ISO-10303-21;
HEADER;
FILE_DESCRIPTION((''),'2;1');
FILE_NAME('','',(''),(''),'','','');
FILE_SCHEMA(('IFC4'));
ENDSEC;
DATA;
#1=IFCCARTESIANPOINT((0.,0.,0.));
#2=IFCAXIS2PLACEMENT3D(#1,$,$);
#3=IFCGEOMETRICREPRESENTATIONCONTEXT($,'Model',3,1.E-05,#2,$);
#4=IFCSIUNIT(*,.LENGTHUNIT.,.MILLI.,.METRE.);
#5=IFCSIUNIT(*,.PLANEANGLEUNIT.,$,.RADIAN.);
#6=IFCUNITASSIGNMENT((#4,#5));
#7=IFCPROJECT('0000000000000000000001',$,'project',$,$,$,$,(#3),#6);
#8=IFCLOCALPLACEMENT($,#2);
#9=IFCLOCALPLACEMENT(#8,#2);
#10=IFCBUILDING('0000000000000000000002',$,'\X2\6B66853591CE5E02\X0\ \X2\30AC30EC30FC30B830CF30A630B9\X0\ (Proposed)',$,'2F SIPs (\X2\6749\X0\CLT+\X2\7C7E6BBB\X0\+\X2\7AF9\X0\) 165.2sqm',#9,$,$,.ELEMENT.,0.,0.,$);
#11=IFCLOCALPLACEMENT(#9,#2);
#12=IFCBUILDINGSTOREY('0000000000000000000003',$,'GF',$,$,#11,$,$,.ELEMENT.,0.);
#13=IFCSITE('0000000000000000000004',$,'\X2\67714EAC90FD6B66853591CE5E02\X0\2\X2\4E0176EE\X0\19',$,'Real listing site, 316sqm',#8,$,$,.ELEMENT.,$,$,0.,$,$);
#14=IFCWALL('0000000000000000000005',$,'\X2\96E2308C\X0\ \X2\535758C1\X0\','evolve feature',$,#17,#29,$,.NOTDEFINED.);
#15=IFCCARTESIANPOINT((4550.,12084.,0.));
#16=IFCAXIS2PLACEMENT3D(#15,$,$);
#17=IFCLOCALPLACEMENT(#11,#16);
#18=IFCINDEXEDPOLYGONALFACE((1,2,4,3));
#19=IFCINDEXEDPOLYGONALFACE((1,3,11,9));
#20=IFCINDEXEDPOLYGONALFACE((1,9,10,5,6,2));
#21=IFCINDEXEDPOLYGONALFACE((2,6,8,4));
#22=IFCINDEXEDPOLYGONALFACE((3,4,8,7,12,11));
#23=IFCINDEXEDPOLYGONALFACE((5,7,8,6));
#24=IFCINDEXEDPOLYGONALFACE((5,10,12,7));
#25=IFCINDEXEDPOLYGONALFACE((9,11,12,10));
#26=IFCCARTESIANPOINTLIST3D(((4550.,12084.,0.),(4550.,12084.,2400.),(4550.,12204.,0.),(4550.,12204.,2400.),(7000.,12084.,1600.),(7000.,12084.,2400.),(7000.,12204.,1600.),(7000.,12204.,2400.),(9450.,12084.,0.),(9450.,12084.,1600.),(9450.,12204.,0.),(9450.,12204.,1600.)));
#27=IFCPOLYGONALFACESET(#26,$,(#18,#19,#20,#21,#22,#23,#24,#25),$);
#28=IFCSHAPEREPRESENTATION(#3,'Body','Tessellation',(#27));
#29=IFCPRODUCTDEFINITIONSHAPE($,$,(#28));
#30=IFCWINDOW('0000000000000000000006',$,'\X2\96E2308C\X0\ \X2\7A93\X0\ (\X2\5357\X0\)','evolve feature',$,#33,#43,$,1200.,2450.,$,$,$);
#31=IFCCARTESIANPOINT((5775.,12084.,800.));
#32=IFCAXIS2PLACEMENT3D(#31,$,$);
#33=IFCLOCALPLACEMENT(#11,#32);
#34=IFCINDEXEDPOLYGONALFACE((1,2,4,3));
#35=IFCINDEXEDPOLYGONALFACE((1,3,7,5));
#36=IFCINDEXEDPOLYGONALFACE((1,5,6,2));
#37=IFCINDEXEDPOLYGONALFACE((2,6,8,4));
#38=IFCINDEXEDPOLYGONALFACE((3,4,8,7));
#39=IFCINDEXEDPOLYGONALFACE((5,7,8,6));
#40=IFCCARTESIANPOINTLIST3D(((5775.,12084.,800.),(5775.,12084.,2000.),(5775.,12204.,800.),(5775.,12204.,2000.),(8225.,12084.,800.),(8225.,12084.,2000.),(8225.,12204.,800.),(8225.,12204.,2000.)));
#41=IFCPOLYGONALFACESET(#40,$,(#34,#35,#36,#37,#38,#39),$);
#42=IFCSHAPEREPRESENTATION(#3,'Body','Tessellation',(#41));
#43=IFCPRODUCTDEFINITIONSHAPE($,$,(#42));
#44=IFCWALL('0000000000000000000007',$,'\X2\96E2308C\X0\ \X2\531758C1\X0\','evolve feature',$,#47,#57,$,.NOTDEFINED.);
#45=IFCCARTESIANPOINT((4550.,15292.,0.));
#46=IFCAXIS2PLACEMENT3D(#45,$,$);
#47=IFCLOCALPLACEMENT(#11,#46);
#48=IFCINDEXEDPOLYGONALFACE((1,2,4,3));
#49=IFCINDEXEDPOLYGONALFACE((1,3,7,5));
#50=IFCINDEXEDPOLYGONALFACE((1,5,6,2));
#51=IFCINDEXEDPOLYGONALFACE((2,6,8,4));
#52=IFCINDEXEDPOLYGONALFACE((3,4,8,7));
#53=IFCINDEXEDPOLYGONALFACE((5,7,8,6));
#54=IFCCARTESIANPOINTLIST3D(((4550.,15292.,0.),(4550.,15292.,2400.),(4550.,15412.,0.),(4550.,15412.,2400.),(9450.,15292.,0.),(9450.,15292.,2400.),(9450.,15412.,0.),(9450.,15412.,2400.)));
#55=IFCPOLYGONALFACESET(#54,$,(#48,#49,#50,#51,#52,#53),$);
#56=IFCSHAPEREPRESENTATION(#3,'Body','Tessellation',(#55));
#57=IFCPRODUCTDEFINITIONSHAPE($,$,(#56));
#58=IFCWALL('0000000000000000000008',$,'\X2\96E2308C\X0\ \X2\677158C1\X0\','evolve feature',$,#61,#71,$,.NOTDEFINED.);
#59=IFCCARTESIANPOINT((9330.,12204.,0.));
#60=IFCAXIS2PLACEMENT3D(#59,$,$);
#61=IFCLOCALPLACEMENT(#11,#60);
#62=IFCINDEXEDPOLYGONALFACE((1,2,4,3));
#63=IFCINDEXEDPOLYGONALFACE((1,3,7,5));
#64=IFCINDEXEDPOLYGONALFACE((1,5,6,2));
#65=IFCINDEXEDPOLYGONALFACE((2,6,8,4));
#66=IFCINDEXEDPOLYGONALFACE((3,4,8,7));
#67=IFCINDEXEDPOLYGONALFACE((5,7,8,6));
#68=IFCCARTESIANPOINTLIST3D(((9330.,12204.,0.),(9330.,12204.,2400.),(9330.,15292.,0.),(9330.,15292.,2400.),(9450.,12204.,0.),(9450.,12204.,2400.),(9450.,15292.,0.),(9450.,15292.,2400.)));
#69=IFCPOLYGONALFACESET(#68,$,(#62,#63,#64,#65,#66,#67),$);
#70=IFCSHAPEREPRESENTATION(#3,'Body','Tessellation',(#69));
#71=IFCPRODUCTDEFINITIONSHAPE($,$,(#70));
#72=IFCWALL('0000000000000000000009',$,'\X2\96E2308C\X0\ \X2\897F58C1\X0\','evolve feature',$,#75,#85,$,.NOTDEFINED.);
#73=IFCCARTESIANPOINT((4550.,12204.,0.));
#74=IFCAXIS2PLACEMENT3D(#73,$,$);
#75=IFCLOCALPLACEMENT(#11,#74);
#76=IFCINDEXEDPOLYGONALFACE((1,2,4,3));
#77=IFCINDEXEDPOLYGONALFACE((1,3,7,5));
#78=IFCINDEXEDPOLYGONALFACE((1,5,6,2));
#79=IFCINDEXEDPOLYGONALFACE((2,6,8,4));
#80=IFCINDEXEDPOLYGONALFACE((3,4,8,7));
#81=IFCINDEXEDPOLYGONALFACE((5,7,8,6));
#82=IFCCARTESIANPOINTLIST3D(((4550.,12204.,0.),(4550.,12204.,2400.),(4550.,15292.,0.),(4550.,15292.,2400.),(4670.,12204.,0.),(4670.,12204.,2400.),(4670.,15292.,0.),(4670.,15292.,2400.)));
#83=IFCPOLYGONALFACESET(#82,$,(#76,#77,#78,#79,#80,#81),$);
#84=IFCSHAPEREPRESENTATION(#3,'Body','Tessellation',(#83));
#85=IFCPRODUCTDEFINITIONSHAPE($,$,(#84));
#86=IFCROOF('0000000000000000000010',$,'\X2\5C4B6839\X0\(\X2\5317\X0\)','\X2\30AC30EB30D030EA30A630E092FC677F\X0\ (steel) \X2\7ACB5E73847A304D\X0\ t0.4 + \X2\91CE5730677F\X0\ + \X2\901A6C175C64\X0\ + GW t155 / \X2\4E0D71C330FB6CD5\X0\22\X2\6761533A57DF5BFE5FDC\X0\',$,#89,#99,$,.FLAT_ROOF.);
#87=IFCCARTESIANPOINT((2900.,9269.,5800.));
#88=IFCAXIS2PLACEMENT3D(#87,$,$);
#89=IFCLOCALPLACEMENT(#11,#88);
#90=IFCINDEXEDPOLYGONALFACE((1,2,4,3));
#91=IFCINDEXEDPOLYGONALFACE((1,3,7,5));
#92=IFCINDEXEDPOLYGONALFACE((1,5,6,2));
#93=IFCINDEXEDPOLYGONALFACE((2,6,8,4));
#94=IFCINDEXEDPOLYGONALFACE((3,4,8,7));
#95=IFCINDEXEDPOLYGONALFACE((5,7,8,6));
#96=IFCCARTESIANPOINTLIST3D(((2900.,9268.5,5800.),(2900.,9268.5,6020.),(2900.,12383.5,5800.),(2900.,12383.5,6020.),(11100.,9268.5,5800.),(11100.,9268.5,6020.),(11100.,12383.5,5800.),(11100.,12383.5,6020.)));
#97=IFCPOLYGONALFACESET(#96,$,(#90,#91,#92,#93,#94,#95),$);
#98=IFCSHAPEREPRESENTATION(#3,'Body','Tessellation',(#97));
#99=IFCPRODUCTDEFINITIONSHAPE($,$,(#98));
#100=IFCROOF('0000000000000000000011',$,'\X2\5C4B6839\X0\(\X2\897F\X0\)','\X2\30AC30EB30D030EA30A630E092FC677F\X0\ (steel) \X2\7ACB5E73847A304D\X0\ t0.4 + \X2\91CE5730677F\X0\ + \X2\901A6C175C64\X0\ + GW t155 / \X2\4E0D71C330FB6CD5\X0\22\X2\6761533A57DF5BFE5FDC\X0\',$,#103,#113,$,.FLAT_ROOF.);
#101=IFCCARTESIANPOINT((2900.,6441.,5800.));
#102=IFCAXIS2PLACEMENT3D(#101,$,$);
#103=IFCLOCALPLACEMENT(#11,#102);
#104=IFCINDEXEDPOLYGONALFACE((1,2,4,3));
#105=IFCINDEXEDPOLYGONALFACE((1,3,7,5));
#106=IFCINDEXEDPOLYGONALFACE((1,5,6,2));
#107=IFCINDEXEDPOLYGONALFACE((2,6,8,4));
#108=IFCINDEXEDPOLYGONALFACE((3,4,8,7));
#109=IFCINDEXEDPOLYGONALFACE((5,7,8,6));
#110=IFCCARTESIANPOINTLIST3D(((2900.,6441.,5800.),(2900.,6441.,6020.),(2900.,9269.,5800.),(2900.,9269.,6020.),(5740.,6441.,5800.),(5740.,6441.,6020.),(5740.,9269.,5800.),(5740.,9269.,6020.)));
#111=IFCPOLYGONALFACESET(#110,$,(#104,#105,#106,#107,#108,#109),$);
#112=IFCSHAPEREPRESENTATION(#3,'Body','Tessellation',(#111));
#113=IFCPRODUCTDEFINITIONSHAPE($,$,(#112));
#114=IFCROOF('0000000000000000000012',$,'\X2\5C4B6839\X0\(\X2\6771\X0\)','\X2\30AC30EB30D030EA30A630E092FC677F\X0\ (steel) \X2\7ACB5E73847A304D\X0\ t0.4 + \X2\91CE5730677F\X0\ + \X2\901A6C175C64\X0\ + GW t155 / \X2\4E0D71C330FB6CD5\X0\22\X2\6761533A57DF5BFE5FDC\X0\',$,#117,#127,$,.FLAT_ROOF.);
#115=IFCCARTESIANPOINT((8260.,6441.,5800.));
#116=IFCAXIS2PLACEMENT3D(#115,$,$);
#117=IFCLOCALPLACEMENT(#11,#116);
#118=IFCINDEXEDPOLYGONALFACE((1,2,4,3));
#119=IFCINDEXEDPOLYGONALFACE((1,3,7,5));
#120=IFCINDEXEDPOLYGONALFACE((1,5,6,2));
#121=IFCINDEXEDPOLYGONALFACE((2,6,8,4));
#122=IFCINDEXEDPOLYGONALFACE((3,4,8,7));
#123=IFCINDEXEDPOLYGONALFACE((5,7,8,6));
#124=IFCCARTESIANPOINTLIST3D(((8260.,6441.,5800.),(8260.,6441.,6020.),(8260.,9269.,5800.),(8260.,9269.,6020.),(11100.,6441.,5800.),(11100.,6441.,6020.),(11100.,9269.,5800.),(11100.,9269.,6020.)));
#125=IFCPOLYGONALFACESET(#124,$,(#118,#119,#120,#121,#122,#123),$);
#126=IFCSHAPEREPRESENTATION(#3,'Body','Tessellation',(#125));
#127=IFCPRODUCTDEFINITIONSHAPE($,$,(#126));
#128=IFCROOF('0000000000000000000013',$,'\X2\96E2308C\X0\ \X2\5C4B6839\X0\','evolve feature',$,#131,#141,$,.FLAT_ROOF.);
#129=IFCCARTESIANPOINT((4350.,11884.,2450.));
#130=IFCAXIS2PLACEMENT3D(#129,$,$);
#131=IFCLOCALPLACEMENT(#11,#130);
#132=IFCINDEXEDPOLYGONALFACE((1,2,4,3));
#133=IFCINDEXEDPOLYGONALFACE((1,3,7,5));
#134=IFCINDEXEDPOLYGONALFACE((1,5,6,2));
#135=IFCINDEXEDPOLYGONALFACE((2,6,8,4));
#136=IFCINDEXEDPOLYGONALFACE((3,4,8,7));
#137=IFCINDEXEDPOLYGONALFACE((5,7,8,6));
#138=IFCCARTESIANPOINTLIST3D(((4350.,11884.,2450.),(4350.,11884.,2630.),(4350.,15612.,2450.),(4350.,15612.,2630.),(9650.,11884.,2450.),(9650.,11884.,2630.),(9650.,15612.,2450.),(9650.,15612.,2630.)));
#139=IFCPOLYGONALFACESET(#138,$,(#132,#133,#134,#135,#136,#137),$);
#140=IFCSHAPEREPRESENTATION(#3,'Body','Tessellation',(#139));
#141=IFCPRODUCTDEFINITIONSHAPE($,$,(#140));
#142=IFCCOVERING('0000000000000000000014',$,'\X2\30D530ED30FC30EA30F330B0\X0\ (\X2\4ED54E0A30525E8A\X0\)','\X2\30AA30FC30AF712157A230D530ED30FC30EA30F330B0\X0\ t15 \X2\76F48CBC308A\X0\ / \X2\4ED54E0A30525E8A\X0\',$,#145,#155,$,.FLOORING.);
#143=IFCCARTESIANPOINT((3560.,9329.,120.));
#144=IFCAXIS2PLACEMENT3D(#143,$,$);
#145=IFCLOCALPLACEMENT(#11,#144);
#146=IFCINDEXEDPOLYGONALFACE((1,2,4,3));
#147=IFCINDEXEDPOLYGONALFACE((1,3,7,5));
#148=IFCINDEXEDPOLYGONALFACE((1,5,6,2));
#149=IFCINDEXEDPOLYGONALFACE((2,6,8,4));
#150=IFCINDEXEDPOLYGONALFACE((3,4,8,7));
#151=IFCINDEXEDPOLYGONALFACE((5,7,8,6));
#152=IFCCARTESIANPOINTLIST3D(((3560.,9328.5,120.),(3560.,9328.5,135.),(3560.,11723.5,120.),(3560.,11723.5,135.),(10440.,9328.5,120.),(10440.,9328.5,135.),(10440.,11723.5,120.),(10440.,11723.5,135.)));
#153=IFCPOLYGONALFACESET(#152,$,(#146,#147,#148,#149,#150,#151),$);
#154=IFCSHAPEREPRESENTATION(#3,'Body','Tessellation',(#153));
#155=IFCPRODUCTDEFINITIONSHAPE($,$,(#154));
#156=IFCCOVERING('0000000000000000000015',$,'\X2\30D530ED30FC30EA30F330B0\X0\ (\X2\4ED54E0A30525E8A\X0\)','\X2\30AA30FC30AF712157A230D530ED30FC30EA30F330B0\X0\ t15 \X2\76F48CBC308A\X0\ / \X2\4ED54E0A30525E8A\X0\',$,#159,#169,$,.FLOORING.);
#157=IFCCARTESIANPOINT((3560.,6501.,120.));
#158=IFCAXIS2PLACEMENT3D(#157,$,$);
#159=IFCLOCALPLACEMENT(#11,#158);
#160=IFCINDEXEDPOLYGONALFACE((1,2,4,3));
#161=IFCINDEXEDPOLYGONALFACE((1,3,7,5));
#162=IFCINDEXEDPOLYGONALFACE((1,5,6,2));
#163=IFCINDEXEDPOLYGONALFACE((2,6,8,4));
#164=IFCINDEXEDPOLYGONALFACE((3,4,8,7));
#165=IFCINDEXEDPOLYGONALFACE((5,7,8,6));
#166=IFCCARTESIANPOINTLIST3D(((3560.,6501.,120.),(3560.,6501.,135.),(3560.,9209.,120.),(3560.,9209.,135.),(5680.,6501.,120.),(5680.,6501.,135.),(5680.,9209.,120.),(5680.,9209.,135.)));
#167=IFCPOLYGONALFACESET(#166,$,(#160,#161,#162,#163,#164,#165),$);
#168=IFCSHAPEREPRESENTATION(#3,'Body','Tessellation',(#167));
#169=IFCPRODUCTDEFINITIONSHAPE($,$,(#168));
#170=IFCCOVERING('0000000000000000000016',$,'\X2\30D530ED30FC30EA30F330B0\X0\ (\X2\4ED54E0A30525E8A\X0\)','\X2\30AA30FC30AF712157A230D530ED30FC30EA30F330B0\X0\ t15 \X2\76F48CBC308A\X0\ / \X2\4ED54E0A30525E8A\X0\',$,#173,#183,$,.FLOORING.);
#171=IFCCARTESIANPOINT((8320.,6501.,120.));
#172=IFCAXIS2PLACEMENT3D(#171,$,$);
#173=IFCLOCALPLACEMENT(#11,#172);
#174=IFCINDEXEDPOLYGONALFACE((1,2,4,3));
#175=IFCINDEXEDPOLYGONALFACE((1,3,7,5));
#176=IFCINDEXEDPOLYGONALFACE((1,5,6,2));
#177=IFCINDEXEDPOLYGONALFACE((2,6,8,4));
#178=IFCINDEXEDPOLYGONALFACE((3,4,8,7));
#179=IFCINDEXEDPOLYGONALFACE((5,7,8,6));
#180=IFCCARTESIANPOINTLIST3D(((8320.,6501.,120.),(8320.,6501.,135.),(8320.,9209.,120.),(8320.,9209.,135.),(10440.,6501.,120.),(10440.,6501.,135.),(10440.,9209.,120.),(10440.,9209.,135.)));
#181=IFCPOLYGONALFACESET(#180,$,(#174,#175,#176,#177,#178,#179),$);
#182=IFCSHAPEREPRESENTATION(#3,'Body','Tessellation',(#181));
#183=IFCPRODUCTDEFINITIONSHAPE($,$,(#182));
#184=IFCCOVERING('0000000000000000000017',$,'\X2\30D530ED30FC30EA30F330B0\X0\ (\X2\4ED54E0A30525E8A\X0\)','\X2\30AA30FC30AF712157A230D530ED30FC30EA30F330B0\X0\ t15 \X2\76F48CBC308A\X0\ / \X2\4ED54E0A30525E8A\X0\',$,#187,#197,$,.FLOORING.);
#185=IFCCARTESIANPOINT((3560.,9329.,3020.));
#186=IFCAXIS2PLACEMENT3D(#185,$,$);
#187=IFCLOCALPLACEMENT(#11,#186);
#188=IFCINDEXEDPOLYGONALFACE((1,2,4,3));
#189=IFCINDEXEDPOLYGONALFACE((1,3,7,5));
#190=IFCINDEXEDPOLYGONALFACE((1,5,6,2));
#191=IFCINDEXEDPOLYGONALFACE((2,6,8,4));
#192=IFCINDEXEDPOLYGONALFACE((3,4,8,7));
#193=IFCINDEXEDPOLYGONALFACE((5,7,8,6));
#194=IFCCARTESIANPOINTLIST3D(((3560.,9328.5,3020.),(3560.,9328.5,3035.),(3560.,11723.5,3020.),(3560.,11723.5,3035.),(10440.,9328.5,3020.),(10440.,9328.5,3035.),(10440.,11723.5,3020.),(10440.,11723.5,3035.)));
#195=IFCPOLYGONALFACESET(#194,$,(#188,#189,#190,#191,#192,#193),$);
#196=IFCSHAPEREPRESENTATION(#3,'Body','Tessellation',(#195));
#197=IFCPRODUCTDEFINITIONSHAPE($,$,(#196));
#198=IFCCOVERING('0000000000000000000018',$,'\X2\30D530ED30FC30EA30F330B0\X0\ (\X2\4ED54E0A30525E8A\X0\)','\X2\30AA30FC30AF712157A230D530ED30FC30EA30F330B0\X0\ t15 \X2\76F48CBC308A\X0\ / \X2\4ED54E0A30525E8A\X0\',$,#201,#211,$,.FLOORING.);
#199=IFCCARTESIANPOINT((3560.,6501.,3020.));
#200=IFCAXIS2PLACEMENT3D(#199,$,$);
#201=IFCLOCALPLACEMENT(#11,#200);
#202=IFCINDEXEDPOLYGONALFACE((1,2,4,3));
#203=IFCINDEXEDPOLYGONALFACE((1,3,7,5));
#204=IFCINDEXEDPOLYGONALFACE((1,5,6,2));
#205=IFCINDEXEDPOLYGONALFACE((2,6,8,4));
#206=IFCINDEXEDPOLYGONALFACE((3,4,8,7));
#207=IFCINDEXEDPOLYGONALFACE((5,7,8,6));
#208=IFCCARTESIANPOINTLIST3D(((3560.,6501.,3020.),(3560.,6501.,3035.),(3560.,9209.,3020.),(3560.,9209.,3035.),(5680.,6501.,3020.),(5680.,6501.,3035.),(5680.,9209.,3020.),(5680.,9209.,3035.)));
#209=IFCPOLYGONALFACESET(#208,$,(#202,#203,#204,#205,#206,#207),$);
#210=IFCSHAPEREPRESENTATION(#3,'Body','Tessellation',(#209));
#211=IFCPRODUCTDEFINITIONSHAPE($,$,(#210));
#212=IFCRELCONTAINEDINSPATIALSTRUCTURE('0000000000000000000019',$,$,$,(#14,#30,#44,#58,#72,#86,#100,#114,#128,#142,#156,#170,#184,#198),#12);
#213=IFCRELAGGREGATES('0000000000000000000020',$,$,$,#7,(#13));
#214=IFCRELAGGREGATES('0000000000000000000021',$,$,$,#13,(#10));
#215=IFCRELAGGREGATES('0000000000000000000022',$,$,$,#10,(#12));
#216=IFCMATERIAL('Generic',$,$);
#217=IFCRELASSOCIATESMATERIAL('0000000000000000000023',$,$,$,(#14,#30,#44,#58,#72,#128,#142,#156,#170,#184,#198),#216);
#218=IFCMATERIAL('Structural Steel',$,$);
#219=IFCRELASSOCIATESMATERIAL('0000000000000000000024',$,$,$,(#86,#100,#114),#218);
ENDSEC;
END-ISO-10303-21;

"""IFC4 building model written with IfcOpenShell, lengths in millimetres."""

from ifc_helpers import new_model, si_unit, frame, frame_2d, origin, place, context, project, spatial, rectangle, extrude, material, element, fill, save


model = new_model("IFC4")

# Units and contexts
model_context = context("Model", 3, precision=1e-05, world=origin())
ifc_project = project(units=[si_unit("LENGTHUNIT", "METRE", prefix="MILLI"), si_unit("PLANEANGLEUNIT", "RADIAN")], contexts=[model_context])

# Site, building, storey
site_placement = place(None, origin())
site = spatial("IfcSite", under=ifc_project, at=site_placement, Name="東京都武蔵野市2丁目19", ObjectType="Real listing site, 316sqm", CompositionType="ELEMENT", RefElevation=0.0)
building_placement = place(site_placement, origin())
building = spatial("IfcBuilding", under=site, at=building_placement, Name="武蔵野市 ガレージハウス (Proposed)", ObjectType="2F SIPs (杉CLT+籾殻+竹) 165.2sqm", CompositionType="ELEMENT", ElevationOfRefHeight=0.0, ElevationOfTerrain=0.0)
storey_placement = place(building_placement, origin())
storey = spatial("IfcBuildingStorey", under=building, at=storey_placement, Name="GF", CompositionType="ELEMENT", Elevation=0.0)

# Shared definitions
ifc_material_1 = material(Name="Generic")

# Wall, opening, window
wall_1_placement = place(storey_placement, frame((4550.0, 12084.0, 0.0)))
wall_1 = element("IfcWall", 1, at=wall_1_placement, inside=storey, material=ifc_material_1, Name="離れ 南壁", Description="evolve feature", PredefinedType="NOTDEFINED", context=model_context, shape_type="SweptSolid", body=[
    extrude(rectangle(XDim=4900.0, YDim=120.0, at=frame_2d((2450.0, 60.0))), frame((4550.0, 12084.0, 0.0)), (0.0, 0.0, 1.0), 2400.0),
])
opening_1_placement = place(storey_placement, frame((5775.0, 12084.0, 800.0)))
opening_1 = element("IfcOpeningElement", 2, at=opening_1_placement, cuts=wall_1, PredefinedType="NOTDEFINED", context=model_context, shape_type="SweptSolid", body=[
    extrude(rectangle(XDim=2450.0, YDim=120.0, at=frame_2d((1225.0, 60.0))), frame((5775.0, 12084.0, 800.0)), (0.0, 0.0, 1.0), 1200.0),
])
window_1_placement = place(storey_placement, frame((5775.0, 12084.0, 800.0)))
window_1 = element("IfcWindow", 3, at=window_1_placement, inside=storey, material=ifc_material_1, Name="離れ 窓 (南)", Description="evolve feature", OverallHeight=1200.0, OverallWidth=2450.0, context=model_context, shape_type="SweptSolid", body=[
    extrude(rectangle(XDim=2450.0, YDim=120.0, at=frame_2d((1225.0, 60.0))), frame((5775.0, 12084.0, 800.0)), (0.0, 0.0, 1.0), 1200.0),
])
fill(opening_1, window_1)

# Walls
wall_2_placement = place(storey_placement, frame((4550.0, 15292.0, 0.0)))
element("IfcWall", 4, at=wall_2_placement, inside=storey, material=ifc_material_1, Name="離れ 北壁", Description="evolve feature", PredefinedType="NOTDEFINED", context=model_context, shape_type="SweptSolid", body=[
    extrude(rectangle(XDim=4900.0, YDim=120.0, at=frame_2d((2450.0, 60.0))), frame((4550.0, 15292.0, 0.0)), (0.0, 0.0, 1.0), 2400.0),
])
wall_3_placement = place(storey_placement, frame((9330.0, 12204.0, 0.0)))
element("IfcWall", 5, at=wall_3_placement, inside=storey, material=ifc_material_1, Name="離れ 東壁", Description="evolve feature", PredefinedType="NOTDEFINED", context=model_context, shape_type="SweptSolid", body=[
    extrude(rectangle(XDim=120.0, YDim=3088.0, at=frame_2d((60.0, 1544.0))), frame((9330.0, 12204.0, 0.0)), (0.0, 0.0, 1.0), 2400.0),
])
wall_4_placement = place(storey_placement, frame((4550.0, 12204.0, 0.0)))
element("IfcWall", 6, at=wall_4_placement, inside=storey, material=ifc_material_1, Name="離れ 西壁", Description="evolve feature", PredefinedType="NOTDEFINED", context=model_context, shape_type="SweptSolid", body=[
    extrude(rectangle(XDim=120.0, YDim=3088.0, at=frame_2d((60.0, 1544.0))), frame((4550.0, 12204.0, 0.0)), (0.0, 0.0, 1.0), 2400.0),
])

# Roofs
ifc_material_2 = material(Name="Structural Steel")
for number, where, name in (
    (7, (2900.0, 9269.0, 5800.0), "屋根(北)"),
):
    element("IfcRoof", number, at=place(storey_placement, frame(where)), inside=storey, material=ifc_material_2, Name=name, Description="ガルバリウム鋼板 (steel) 立平葺き t0.4 + 野地板 + 通気層 + GW t155 / 不燃・法22条区域対応", PredefinedType="FLAT_ROOF", context=model_context, shape_type="SweptSolid", body=[
        extrude(rectangle(XDim=8200.0, YDim=3115.0, at=frame_2d((4100.0, 1557.0))), frame((2900.0, 9269.0, 5800.0)), (0.0, 0.0, 1.0), 220.0),
    ])
roof_1_placement = place(storey_placement, frame((2900.0, 6441.0, 5800.0)))
element("IfcRoof", 8, at=roof_1_placement, inside=storey, material=ifc_material_2, Name="屋根(西)", Description="ガルバリウム鋼板 (steel) 立平葺き t0.4 + 野地板 + 通気層 + GW t155 / 不燃・法22条区域対応", PredefinedType="FLAT_ROOF", context=model_context, shape_type="SweptSolid", body=[
    extrude(rectangle(XDim=2840.0, YDim=2828.0, at=frame_2d((1420.0, 1414.0))), frame((2900.0, 6441.0, 5800.0)), (0.0, 0.0, 1.0), 220.0),
])
roof_2_placement = place(storey_placement, frame((8260.0, 6441.0, 5800.0)))
element("IfcRoof", 9, at=roof_2_placement, inside=storey, material=ifc_material_2, Name="屋根(東)", Description="ガルバリウム鋼板 (steel) 立平葺き t0.4 + 野地板 + 通気層 + GW t155 / 不燃・法22条区域対応", PredefinedType="FLAT_ROOF", context=model_context, shape_type="SweptSolid", body=[
    extrude(rectangle(XDim=2840.0, YDim=2828.0, at=frame_2d((1420.0, 1414.0))), frame((8260.0, 6441.0, 5800.0)), (0.0, 0.0, 1.0), 220.0),
])
roof_3_placement = place(storey_placement, frame((4350.0, 11884.0, 2450.0)))
element("IfcRoof", 10, at=roof_3_placement, inside=storey, material=ifc_material_1, Name="離れ 屋根", Description="evolve feature", PredefinedType="FLAT_ROOF", context=model_context, shape_type="SweptSolid", body=[
    extrude(rectangle(XDim=5300.0, YDim=3728.0, at=frame_2d((2650.0, 1864.0))), frame((4350.0, 11884.0, 2450.0)), (0.0, 0.0, 1.0), 180.0),
])

# Coverings
covering_1_placement = place(storey_placement, frame((3560.0, 9329.0, 120.0)))
element("IfcCovering", 11, at=covering_1_placement, inside=storey, material=ifc_material_1, Name="フローリング (仕上げ床)", Description="オーク無垢フローリング t15 直貼り / 仕上げ床", PredefinedType="FLOORING", context=model_context, shape_type="SweptSolid", body=[
    extrude(rectangle(XDim=6880.0, YDim=2395.0, at=frame_2d((3440.0, 1197.0))), frame((3560.0, 9329.0, 120.0)), (0.0, 0.0, 1.0), 15.0),
])
covering_2_placement = place(storey_placement, frame((3560.0, 6501.0, 120.0)))
element("IfcCovering", 12, at=covering_2_placement, inside=storey, material=ifc_material_1, Name="フローリング (仕上げ床)", Description="オーク無垢フローリング t15 直貼り / 仕上げ床", PredefinedType="FLOORING", context=model_context, shape_type="SweptSolid", body=[
    extrude(rectangle(XDim=2120.0, YDim=2708.0, at=frame_2d((1060.0, 1354.0))), frame((3560.0, 6501.0, 120.0)), (0.0, 0.0, 1.0), 15.0),
])
covering_3_placement = place(storey_placement, frame((8320.0, 6501.0, 120.0)))
element("IfcCovering", 13, at=covering_3_placement, inside=storey, material=ifc_material_1, Name="フローリング (仕上げ床)", Description="オーク無垢フローリング t15 直貼り / 仕上げ床", PredefinedType="FLOORING", context=model_context, shape_type="SweptSolid", body=[
    extrude(rectangle(XDim=2120.0, YDim=2708.0, at=frame_2d((1060.0, 1354.0))), frame((8320.0, 6501.0, 120.0)), (0.0, 0.0, 1.0), 15.0),
])
covering_4_placement = place(storey_placement, frame((3560.0, 9329.0, 3020.0)))
element("IfcCovering", 14, at=covering_4_placement, inside=storey, material=ifc_material_1, Name="フローリング (仕上げ床)", Description="オーク無垢フローリング t15 直貼り / 仕上げ床", PredefinedType="FLOORING", context=model_context, shape_type="SweptSolid", body=[
    extrude(rectangle(XDim=6880.0, YDim=2395.0, at=frame_2d((3440.0, 1197.0))), frame((3560.0, 9329.0, 3020.0)), (0.0, 0.0, 1.0), 15.0),
])
covering_5_placement = place(storey_placement, frame((3560.0, 6501.0, 3020.0)))
element("IfcCovering", 15, at=covering_5_placement, inside=storey, material=ifc_material_1, Name="フローリング (仕上げ床)", Description="オーク無垢フローリング t15 直貼り / 仕上げ床", PredefinedType="FLOORING", context=model_context, shape_type="SweptSolid", body=[
    extrude(rectangle(XDim=2120.0, YDim=2708.0, at=frame_2d((1060.0, 1354.0))), frame((3560.0, 6501.0, 3020.0)), (0.0, 0.0, 1.0), 15.0),
])

save(model, "model.ifc")
